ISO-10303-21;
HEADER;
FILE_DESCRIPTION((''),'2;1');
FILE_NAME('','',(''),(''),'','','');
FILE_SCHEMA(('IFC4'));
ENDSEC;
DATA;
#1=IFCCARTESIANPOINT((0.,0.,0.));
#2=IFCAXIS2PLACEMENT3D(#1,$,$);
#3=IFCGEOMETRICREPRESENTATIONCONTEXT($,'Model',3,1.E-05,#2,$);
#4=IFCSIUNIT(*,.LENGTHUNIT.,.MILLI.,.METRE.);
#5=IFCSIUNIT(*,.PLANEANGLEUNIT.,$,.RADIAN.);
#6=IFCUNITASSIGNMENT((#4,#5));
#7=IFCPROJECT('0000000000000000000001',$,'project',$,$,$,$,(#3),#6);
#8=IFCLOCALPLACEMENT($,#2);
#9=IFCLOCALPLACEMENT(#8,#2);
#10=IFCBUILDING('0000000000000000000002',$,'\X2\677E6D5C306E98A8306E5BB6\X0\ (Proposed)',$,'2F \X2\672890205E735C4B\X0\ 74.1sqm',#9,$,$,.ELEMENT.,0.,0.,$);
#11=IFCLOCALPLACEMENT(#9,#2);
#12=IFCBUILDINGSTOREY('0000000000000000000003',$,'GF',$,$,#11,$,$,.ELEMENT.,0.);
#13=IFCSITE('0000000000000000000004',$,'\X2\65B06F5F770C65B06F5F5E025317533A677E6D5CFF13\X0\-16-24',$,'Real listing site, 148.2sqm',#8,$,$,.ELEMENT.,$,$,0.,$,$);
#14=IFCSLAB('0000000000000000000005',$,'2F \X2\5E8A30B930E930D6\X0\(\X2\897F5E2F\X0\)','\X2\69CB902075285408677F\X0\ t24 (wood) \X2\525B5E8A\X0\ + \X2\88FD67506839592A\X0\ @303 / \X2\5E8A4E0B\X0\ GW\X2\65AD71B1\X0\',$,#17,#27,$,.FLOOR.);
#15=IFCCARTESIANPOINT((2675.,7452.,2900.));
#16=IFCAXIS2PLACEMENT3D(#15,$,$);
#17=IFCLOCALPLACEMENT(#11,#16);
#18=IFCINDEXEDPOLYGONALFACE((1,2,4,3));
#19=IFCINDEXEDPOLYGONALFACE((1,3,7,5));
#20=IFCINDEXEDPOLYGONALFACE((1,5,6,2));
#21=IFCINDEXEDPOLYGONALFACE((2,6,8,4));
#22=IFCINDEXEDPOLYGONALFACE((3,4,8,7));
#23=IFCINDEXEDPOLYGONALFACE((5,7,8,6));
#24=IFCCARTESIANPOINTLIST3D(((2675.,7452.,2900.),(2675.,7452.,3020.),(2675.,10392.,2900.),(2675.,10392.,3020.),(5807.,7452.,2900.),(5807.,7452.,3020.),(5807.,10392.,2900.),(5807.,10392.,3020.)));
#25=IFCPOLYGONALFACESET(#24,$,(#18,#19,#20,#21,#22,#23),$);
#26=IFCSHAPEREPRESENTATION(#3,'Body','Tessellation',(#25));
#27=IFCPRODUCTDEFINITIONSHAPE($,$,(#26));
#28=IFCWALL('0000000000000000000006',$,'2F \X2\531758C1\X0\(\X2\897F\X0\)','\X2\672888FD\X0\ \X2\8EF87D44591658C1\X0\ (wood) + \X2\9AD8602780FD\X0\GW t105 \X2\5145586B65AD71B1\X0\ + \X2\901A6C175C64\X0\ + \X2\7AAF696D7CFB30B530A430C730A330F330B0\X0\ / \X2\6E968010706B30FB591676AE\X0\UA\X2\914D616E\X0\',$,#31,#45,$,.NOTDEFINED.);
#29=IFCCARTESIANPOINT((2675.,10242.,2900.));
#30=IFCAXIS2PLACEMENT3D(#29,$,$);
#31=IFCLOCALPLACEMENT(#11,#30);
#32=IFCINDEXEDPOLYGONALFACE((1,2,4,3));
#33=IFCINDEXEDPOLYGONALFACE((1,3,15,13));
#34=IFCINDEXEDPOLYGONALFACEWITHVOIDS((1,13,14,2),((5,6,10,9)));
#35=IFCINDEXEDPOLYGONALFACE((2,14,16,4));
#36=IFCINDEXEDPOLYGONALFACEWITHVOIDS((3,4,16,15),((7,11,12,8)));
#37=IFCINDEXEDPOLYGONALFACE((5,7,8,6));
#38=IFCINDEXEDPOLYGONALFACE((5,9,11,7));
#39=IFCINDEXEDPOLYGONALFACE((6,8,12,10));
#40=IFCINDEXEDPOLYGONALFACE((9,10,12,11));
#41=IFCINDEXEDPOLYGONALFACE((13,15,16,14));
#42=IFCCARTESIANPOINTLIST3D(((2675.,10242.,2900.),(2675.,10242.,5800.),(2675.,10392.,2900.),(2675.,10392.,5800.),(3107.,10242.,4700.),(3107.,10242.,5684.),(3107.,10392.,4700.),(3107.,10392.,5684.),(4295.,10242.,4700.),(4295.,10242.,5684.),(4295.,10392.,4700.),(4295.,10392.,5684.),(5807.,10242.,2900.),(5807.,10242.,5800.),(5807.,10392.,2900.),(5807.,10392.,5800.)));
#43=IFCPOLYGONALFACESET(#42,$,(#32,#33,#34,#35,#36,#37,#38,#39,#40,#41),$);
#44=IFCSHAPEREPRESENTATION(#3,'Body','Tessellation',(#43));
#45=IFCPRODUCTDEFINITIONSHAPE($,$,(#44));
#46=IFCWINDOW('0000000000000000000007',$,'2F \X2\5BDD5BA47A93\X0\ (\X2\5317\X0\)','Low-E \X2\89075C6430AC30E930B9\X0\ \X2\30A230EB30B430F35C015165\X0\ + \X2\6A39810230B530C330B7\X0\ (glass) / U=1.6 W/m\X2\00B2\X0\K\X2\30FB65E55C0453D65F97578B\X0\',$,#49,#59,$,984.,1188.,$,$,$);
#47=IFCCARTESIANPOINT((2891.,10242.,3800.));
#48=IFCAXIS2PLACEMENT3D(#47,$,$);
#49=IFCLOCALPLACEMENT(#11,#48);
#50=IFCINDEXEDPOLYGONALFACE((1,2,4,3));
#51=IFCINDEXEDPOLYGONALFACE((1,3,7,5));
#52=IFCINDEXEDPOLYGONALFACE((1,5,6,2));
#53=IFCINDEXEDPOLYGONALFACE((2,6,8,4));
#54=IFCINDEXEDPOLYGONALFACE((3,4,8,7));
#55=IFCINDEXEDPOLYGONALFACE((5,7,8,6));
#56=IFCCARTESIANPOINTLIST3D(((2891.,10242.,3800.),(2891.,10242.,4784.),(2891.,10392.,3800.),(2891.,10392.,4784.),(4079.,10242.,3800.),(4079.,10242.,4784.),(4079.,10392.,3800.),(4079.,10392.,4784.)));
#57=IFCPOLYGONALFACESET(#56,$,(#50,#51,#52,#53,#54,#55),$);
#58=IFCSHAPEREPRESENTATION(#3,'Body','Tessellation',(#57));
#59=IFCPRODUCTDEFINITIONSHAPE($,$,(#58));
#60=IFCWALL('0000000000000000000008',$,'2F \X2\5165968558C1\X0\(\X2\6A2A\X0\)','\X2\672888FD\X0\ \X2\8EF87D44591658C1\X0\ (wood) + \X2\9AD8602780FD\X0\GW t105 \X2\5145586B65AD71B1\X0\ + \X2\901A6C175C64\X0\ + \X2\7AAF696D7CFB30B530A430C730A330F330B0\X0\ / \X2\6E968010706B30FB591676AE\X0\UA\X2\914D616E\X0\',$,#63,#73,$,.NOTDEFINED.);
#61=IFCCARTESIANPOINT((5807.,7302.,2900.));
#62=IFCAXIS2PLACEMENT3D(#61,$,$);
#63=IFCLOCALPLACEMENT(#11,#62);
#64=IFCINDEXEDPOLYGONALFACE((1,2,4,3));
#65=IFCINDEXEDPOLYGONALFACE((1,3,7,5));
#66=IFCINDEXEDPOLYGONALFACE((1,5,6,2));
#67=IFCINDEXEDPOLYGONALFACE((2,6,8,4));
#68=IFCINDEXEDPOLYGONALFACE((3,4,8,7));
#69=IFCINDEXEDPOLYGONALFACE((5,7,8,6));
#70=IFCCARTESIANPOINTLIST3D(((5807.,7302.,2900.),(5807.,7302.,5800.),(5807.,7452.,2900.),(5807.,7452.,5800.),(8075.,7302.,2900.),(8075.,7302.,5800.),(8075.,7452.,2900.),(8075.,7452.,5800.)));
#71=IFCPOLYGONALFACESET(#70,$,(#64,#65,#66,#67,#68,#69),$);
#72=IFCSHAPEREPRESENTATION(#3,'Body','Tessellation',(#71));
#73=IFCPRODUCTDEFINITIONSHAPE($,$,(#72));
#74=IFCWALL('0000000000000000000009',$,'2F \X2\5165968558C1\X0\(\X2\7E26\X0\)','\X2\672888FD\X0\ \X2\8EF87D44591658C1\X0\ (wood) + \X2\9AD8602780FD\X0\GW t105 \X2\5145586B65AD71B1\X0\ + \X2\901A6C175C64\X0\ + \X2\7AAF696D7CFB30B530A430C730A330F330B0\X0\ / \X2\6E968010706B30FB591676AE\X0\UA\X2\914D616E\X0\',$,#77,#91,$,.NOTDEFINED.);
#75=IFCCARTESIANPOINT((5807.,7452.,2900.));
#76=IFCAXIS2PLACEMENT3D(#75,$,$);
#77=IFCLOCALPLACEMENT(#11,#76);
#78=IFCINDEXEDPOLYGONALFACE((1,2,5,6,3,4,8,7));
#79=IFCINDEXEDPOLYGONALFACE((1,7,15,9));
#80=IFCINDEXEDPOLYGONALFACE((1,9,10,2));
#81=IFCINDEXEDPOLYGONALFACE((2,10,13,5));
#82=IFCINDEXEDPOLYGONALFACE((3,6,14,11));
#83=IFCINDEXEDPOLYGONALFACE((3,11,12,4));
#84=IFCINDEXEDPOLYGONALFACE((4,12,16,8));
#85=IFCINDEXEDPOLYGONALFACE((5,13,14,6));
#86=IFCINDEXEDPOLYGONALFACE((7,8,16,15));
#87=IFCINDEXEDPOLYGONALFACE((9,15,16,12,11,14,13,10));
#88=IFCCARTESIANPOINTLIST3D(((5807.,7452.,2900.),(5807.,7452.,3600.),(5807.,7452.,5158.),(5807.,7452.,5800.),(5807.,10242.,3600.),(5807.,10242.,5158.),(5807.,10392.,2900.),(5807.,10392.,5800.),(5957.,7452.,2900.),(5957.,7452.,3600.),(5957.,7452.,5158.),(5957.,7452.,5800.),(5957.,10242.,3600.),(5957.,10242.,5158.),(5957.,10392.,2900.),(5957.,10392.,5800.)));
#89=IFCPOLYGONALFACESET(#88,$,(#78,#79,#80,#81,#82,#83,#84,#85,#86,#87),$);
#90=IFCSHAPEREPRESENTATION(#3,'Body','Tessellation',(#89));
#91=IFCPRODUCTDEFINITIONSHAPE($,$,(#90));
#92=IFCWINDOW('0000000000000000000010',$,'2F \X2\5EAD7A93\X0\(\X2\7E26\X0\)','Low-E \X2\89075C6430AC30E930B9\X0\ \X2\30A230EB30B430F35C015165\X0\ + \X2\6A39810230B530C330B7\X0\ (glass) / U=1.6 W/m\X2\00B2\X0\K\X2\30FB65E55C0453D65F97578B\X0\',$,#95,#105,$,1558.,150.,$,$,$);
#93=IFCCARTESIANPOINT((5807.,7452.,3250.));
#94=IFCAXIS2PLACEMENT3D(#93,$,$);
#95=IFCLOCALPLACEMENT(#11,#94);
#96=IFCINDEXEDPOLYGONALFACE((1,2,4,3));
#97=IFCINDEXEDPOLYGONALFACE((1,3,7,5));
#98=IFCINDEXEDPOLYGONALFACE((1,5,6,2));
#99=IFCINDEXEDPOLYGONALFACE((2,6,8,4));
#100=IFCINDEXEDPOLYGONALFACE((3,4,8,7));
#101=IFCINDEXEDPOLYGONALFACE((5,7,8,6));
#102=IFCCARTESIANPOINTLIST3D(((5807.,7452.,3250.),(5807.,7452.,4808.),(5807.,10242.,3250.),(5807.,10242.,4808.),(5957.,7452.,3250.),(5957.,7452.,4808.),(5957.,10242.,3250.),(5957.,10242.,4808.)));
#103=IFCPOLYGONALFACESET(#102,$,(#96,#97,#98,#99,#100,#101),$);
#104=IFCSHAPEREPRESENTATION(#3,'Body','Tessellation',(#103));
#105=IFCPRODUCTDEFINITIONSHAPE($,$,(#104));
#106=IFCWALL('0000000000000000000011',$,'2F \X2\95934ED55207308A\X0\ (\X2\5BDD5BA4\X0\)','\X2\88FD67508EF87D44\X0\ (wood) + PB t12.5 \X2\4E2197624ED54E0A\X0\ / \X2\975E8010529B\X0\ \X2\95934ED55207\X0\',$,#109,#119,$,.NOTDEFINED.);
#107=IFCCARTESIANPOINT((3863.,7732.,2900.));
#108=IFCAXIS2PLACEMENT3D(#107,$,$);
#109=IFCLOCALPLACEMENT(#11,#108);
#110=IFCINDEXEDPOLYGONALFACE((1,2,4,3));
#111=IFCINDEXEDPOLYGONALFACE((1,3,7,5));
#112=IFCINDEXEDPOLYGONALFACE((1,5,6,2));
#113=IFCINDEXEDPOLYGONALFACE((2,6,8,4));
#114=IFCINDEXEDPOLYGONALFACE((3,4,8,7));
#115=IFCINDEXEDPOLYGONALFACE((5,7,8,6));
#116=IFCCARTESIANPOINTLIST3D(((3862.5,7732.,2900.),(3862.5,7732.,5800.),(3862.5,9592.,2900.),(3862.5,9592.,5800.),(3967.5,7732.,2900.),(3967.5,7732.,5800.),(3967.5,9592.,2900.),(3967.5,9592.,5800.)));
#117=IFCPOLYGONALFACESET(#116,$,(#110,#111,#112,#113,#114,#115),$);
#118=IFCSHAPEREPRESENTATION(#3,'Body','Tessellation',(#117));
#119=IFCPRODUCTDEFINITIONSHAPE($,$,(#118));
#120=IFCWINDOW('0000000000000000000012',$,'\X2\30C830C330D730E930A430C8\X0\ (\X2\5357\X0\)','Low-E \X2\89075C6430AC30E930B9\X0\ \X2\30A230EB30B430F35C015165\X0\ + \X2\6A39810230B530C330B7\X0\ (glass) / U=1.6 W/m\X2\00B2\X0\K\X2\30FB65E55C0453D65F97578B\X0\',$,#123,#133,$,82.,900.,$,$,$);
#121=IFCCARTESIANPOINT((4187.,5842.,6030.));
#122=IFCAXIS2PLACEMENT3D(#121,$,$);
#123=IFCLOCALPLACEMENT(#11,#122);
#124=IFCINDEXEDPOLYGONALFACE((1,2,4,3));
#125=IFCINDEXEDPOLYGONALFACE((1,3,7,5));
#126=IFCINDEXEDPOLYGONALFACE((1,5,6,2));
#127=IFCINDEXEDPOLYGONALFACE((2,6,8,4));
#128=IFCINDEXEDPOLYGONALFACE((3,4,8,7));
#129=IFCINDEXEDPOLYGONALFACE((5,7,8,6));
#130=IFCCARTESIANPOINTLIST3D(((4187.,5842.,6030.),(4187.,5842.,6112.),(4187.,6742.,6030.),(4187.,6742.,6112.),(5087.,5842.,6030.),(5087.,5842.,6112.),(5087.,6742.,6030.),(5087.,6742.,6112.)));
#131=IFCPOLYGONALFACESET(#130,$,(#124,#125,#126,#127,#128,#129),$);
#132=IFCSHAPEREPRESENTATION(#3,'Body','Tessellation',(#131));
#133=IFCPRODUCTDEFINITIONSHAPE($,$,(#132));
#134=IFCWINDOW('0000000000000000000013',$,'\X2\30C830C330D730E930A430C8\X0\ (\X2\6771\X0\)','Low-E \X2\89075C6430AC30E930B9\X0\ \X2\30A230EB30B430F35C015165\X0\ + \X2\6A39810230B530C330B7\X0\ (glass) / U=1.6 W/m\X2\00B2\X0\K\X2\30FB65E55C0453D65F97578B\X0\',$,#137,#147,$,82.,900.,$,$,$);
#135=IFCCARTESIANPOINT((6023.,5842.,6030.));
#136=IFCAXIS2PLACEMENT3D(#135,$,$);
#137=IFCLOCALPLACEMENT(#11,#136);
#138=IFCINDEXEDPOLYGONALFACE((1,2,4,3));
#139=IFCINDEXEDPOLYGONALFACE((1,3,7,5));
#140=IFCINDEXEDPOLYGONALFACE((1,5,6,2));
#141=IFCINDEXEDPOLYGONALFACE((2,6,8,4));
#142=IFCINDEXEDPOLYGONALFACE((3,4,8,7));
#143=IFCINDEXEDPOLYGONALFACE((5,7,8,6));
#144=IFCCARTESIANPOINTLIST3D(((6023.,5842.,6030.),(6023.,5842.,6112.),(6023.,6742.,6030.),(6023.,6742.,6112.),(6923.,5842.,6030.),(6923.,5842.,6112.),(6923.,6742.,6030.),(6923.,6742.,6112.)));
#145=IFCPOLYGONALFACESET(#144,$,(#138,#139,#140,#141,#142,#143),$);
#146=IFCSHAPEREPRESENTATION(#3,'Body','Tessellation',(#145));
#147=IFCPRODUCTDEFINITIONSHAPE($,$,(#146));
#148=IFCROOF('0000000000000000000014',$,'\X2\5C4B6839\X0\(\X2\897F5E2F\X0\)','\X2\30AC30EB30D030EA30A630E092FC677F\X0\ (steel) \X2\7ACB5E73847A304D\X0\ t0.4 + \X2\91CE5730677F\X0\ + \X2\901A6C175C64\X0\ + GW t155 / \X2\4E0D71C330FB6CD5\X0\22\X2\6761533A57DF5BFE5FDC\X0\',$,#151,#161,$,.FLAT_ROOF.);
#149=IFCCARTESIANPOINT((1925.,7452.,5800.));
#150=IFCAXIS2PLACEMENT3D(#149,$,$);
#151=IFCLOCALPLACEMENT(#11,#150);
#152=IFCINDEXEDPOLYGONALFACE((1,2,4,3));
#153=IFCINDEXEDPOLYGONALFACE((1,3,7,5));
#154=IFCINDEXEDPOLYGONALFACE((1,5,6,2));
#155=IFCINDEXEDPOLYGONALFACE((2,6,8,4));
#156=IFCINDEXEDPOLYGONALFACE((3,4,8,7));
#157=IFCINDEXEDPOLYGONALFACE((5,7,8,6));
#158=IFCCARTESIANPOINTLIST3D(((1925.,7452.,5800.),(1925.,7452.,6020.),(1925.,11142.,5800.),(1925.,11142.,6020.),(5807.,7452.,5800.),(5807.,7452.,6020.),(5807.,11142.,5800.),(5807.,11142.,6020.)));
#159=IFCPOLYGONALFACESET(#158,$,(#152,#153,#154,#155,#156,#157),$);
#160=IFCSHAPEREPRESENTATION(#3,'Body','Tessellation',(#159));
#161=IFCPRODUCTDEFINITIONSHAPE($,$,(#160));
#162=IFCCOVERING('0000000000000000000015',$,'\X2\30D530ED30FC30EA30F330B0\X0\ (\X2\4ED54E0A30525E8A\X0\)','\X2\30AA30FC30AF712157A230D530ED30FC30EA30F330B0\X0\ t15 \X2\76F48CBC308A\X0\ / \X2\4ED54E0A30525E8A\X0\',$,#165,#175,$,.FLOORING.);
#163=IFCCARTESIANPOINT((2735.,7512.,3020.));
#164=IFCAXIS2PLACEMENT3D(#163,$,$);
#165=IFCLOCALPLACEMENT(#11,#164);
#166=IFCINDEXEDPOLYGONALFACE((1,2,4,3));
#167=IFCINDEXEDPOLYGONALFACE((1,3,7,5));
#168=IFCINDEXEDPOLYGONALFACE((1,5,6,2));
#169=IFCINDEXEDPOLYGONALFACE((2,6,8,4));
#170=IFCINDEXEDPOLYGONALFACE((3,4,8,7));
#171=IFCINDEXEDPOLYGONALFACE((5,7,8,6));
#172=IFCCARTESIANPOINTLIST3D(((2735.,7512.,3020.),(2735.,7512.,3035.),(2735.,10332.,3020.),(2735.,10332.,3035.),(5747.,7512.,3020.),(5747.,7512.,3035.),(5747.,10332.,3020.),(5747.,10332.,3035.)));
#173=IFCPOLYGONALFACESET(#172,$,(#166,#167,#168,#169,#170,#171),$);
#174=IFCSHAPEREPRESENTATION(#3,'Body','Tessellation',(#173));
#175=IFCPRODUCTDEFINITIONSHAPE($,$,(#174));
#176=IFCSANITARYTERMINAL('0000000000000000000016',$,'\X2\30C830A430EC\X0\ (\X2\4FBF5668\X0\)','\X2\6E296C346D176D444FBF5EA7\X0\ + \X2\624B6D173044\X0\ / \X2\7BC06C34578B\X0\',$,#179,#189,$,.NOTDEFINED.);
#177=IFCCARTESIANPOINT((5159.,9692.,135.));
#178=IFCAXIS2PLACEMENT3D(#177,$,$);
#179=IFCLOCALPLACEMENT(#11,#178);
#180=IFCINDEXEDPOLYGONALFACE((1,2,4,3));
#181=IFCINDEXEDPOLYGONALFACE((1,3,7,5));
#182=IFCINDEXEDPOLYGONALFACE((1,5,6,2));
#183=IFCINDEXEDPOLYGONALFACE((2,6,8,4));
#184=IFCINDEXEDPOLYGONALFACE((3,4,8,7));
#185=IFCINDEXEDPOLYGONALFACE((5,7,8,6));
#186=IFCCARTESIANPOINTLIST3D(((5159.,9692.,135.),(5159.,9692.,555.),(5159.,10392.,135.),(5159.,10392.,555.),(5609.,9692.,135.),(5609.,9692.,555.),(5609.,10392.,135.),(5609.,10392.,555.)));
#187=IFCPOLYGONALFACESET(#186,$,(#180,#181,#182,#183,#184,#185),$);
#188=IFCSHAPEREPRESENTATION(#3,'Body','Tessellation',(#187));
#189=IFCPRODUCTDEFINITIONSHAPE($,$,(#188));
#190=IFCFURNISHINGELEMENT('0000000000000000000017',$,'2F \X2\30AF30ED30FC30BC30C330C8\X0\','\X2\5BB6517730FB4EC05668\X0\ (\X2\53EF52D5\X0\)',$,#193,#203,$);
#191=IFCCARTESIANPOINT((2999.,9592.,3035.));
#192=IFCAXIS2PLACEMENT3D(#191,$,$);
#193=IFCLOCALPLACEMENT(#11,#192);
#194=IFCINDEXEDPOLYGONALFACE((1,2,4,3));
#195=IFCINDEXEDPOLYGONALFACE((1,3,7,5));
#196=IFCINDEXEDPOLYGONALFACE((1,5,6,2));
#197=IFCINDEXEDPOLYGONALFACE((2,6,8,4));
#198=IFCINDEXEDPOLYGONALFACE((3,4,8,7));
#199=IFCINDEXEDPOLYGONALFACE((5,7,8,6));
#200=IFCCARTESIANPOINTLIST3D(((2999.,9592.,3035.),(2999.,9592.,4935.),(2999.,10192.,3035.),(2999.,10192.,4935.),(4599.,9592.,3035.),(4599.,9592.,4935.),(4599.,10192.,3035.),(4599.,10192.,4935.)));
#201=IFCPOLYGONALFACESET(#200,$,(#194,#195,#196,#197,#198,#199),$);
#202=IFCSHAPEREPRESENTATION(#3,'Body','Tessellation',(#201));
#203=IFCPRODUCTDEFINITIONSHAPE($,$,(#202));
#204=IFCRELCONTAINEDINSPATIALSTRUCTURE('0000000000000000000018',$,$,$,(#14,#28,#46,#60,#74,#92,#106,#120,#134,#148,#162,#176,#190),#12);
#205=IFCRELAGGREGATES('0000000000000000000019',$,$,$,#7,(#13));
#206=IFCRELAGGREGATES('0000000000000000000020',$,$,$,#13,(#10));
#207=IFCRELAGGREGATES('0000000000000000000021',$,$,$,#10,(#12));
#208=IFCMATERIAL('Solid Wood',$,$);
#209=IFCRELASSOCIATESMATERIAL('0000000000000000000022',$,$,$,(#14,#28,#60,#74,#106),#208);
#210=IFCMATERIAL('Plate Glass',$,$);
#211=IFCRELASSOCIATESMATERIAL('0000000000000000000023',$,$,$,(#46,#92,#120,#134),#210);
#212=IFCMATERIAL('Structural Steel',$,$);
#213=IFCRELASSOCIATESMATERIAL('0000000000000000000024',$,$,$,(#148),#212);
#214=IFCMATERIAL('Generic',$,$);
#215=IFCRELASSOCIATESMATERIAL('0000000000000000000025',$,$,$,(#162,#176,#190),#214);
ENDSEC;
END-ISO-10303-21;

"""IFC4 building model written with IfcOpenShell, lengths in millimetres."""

from ifc_helpers import new_model, si_unit, frame, frame_2d, origin, place, context, project, spatial, rectangle, extrude, material, element, fill, save


model = new_model("IFC4")

# Units and contexts
model_context = context("Model", 3, precision=1e-05, world=origin())
ifc_project = project(units=[si_unit("LENGTHUNIT", "METRE", prefix="MILLI"), si_unit("PLANEANGLEUNIT", "RADIAN")], contexts=[model_context])

# Site, building, storey
site_placement = place(None, origin())
site = spatial("IfcSite", under=ifc_project, at=site_placement, Name="新潟県新潟市北区松浜３-16-24", ObjectType="Real listing site, 148.2sqm", CompositionType="ELEMENT", RefElevation=0.0)
building_placement = place(site_placement, origin())
building = spatial("IfcBuilding", under=site, at=building_placement, Name="松浜の風の家 (Proposed)", ObjectType="2F 木造平屋 74.1sqm", CompositionType="ELEMENT", ElevationOfRefHeight=0.0, ElevationOfTerrain=0.0)
storey_placement = place(building_placement, origin())
storey = spatial("IfcBuildingStorey", under=building, at=storey_placement, Name="GF", CompositionType="ELEMENT", Elevation=0.0)

# Slab
ifc_material_1 = material(Name="Solid Wood")
slab_placement = place(storey_placement, frame((2675.0, 7452.0, 2900.0)))
element("IfcSlab", 1, at=slab_placement, inside=storey, material=ifc_material_1, Name="2F 床スラブ(西帯)", Description="構造用合板 t24 (wood) 剛床 + 製材根太 @303 / 床下 GW断熱", PredefinedType="FLOOR", context=model_context, shape_type="SweptSolid", body=[
    extrude(rectangle(XDim=3132.0, YDim=2940.0, at=frame_2d((1566.0, 1470.0))), frame((2675.0, 7452.0, 2900.0)), (0.0, 0.0, 1.0), 120.0),
])

# Wall, opening, window
wall_1_placement = place(storey_placement, frame((2675.0, 10242.0, 2900.0)))
wall_1 = element("IfcWall", 2, at=wall_1_placement, inside=storey, material=ifc_material_1, Name="2F 北壁(西)", Description="木製 軸組外壁 (wood) + 高性能GW t105 充填断熱 + 通気層 + 窯業系サイディング / 準耐火・外皮UA配慮", PredefinedType="NOTDEFINED", context=model_context, shape_type="SweptSolid", body=[
    extrude(rectangle(XDim=3132.0, YDim=150.0, at=frame_2d((1566.0, 75.0))), frame((2675.0, 10242.0, 2900.0)), (0.0, 0.0, 1.0), 2900.0),
])
opening_1_placement = place(storey_placement, frame((2891.0, 10242.0, 3800.0)))
opening_1 = element("IfcOpeningElement", 3, at=opening_1_placement, cuts=wall_1, PredefinedType="NOTDEFINED", context=model_context, shape_type="SweptSolid", body=[
    extrude(rectangle(XDim=1188.0, YDim=150.0, at=frame_2d((594.0, 75.0))), frame((2891.0, 10242.0, 3800.0)), (0.0, 0.0, 1.0), 984.0),
])
ifc_material_2 = material(Name="Plate Glass")
window_1_placement = place(storey_placement, frame((2891.0, 10242.0, 3800.0)))
window_1 = element("IfcWindow", 4, at=window_1_placement, inside=storey, material=ifc_material_2, Name="2F 寝室窓 (北)", Description="Low-E 複層ガラス アルゴン封入 + 樹脂サッシ (glass) / U=1.6 W/m²K・日射取得型", OverallHeight=984.0, OverallWidth=1188.0, context=model_context, shape_type="SweptSolid", body=[
    extrude(rectangle(XDim=1188.0, YDim=150.0, at=frame_2d((594.0, 75.0))), frame((2891.0, 10242.0, 3800.0)), (0.0, 0.0, 1.0), 984.0),
])
fill(opening_1, window_1)

# Wall
wall_2_placement = place(storey_placement, frame((5807.0, 7302.0, 2900.0)))
element("IfcWall", 5, at=wall_2_placement, inside=storey, material=ifc_material_1, Name="2F 入隅壁(横)", Description="木製 軸組外壁 (wood) + 高性能GW t105 充填断熱 + 通気層 + 窯業系サイディング / 準耐火・外皮UA配慮", PredefinedType="NOTDEFINED", context=model_context, shape_type="SweptSolid", body=[
    extrude(rectangle(XDim=2268.0, YDim=150.0, at=frame_2d((1134.0, 75.0))), frame((5807.0, 7302.0, 2900.0)), (0.0, 0.0, 1.0), 2900.0),
])

# Wall, opening, window
wall_3_placement = place(storey_placement, frame((5807.0, 7452.0, 2900.0)))
wall_3 = element("IfcWall", 6, at=wall_3_placement, inside=storey, material=ifc_material_1, Name="2F 入隅壁(縦)", Description="木製 軸組外壁 (wood) + 高性能GW t105 充填断熱 + 通気層 + 窯業系サイディング / 準耐火・外皮UA配慮", PredefinedType="NOTDEFINED", context=model_context, shape_type="SweptSolid", body=[
    extrude(rectangle(XDim=150.0, YDim=2940.0, at=frame_2d((75.0, 1470.0))), frame((5807.0, 7452.0, 2900.0)), (0.0, 0.0, 1.0), 2900.0),
])
opening_2_placement = place(storey_placement, frame((5807.0, 7452.0, 3250.0)))
opening_2 = element("IfcOpeningElement", 7, at=opening_2_placement, cuts=wall_3, PredefinedType="NOTDEFINED", context=model_context, shape_type="SweptSolid", body=[
    extrude(rectangle(XDim=150.0, YDim=2790.0, at=frame_2d((75.0, 1395.0))), frame((5807.0, 7452.0, 3250.0)), (0.0, 0.0, 1.0), 1558.0),
])
window_2_placement = place(storey_placement, frame((5807.0, 7452.0, 3250.0)))
window_2 = element("IfcWindow", 8, at=window_2_placement, inside=storey, material=ifc_material_2, Name="2F 庭窓(縦)", Description="Low-E 複層ガラス アルゴン封入 + 樹脂サッシ (glass) / U=1.6 W/m²K・日射取得型", OverallHeight=1558.0, OverallWidth=150.0, context=model_context, shape_type="SweptSolid", body=[
    extrude(rectangle(XDim=150.0, YDim=2790.0, at=frame_2d((75.0, 1395.0))), frame((5807.0, 7452.0, 3250.0)), (0.0, 0.0, 1.0), 1558.0),
])
fill(opening_2, window_2)

# Wall
wall_4_placement = place(storey_placement, frame((3863.0, 7732.0, 2900.0)))
element("IfcWall", 9, at=wall_4_placement, inside=storey, material=ifc_material_1, Name="2F 間仕切り (寝室)", Description="製材軸組 (wood) + PB t12.5 両面仕上 / 非耐力 間仕切", PredefinedType="NOTDEFINED", context=model_context, shape_type="SweptSolid", body=[
    extrude(rectangle(XDim=105.0, YDim=1860.0, at=frame_2d((52.0, 930.0))), frame((3863.0, 7732.0, 2900.0)), (0.0, 0.0, 1.0), 2900.0),
])

# Windows
window_3_placement = place(storey_placement, frame((4187.0, 5842.0, 6030.0)))
element("IfcWindow", 10, at=window_3_placement, inside=storey, material=ifc_material_2, Name="トップライト (南)", Description="Low-E 複層ガラス アルゴン封入 + 樹脂サッシ (glass) / U=1.6 W/m²K・日射取得型", OverallHeight=82.0, OverallWidth=900.0, context=model_context, shape_type="SweptSolid", body=[
    extrude(rectangle(XDim=900.0, YDim=900.0, at=frame_2d((450.0, 450.0))), frame((4187.0, 5842.0, 6030.0)), (0.0, 0.0, 1.0), 82.0),
])
window_4_placement = place(storey_placement, frame((6023.0, 5842.0, 6030.0)))
element("IfcWindow", 11, at=window_4_placement, inside=storey, material=ifc_material_2, Name="トップライト (東)", Description="Low-E 複層ガラス アルゴン封入 + 樹脂サッシ (glass) / U=1.6 W/m²K・日射取得型", OverallHeight=82.0, OverallWidth=900.0, context=model_context, shape_type="SweptSolid", body=[
    extrude(rectangle(XDim=900.0, YDim=900.0, at=frame_2d((450.0, 450.0))), frame((6023.0, 5842.0, 6030.0)), (0.0, 0.0, 1.0), 82.0),
])

# Roof
ifc_material_3 = material(Name="Structural Steel")
for number, where, name in (
    (12, (1925.0, 7452.0, 5800.0), "屋根(西帯)"),
):
    element("IfcRoof", number, at=place(storey_placement, frame(where)), inside=storey, material=ifc_material_3, Name=name, Description="ガルバリウム鋼板 (steel) 立平葺き t0.4 + 野地板 + 通気層 + GW t155 / 不燃・法22条区域対応", PredefinedType="FLAT_ROOF", context=model_context, shape_type="SweptSolid", body=[
        extrude(rectangle(XDim=3882.0, YDim=3690.0, at=frame_2d((1941.0, 1845.0))), frame((1925.0, 7452.0, 5800.0)), (0.0, 0.0, 1.0), 220.0),
    ])

# Covering
ifc_material_4 = material(Name="Generic")
covering_placement = place(storey_placement, frame((2735.0, 7512.0, 3020.0)))
element("IfcCovering", 13, at=covering_placement, inside=storey, material=ifc_material_4, Name="フローリング (仕上げ床)", Description="オーク無垢フローリング t15 直貼り / 仕上げ床", PredefinedType="FLOORING", context=model_context, shape_type="SweptSolid", body=[
    extrude(rectangle(XDim=3012.0, YDim=2820.0, at=frame_2d((1506.0, 1410.0))), frame((2735.0, 7512.0, 3020.0)), (0.0, 0.0, 1.0), 15.0),
])

# Sanitary terminal
sanitary_terminal_placement = place(storey_placement, frame((5159.0, 9692.0, 135.0)))
element("IfcSanitaryTerminal", 14, at=sanitary_terminal_placement, inside=storey, material=ifc_material_4, Name="トイレ (便器)", Description="温水洗浄便座 + 手洗い / 節水型", PredefinedType="NOTDEFINED", context=model_context, shape_type="SweptSolid", body=[
    extrude(rectangle(XDim=450.0, YDim=700.0, at=frame_2d((225.0, 350.0))), frame((5159.0, 9692.0, 135.0)), (0.0, 0.0, 1.0), 420.0),
])

# Furnishing element
furnishing_1_placement = place(storey_placement, frame((2999.0, 9592.0, 3035.0)))
element("IfcFurnishingElement", 15, at=furnishing_1_placement, inside=storey, material=ifc_material_4, Name="2F クローゼット", Description="家具・什器 (可動)", context=model_context, shape_type="SweptSolid", body=[
    extrude(rectangle(XDim=1600.0, YDim=600.0, at=frame_2d((800.0, 300.0))), frame((2999.0, 9592.0, 3035.0)), (0.0, 0.0, 1.0), 1900.0),
])

save(model, "model.ifc")
